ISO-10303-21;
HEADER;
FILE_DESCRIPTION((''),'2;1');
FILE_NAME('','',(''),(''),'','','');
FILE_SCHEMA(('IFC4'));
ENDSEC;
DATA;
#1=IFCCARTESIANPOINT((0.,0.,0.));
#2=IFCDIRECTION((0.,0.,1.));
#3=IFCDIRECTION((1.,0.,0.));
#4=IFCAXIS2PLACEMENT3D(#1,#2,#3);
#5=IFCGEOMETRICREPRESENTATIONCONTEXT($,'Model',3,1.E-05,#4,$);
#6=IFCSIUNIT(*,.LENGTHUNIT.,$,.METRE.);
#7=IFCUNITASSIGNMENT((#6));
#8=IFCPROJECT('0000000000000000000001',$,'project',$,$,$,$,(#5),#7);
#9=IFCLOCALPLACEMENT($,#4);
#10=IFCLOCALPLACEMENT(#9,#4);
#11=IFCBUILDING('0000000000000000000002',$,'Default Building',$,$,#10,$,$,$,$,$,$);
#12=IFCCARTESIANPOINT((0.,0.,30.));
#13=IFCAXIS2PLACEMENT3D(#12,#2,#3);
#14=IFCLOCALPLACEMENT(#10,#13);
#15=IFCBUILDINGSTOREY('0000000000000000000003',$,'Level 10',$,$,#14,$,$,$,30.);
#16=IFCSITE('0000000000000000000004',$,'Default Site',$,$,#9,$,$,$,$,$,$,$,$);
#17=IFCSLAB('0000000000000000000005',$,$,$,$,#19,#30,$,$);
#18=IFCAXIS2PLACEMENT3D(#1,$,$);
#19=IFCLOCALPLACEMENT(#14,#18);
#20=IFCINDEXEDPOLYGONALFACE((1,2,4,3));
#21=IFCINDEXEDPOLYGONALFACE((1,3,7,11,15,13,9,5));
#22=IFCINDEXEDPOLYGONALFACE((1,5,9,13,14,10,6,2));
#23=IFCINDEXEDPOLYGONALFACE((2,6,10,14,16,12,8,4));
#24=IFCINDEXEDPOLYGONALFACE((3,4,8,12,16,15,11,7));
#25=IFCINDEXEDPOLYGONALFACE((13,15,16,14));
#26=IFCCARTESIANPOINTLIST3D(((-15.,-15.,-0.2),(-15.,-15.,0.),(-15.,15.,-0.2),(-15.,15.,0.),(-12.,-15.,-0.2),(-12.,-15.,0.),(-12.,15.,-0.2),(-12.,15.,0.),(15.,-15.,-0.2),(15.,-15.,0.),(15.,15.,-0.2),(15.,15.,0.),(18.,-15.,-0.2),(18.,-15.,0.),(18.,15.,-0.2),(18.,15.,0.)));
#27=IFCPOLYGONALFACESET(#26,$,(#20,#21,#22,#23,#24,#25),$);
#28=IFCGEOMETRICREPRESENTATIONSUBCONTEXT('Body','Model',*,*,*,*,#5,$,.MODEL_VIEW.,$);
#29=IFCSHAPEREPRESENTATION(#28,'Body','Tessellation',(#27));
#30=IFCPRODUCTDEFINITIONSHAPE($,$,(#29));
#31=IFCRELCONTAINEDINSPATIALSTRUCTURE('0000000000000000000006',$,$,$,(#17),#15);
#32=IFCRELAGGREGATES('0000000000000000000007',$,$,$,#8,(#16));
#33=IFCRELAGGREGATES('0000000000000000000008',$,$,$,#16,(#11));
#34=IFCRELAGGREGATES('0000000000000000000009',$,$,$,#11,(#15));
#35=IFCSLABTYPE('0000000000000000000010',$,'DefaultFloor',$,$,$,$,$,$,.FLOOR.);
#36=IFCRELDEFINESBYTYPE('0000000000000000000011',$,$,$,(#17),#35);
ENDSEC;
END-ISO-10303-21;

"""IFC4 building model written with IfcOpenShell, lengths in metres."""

from ifc_helpers import new_model, si_unit, frame, origin_with_axes, place, context, subcontext, project, spatial, polyline, outline, extrude, type_object, element, save


model = new_model("IFC4")

# Units and contexts
model_context = context("Model", 3, precision=1e-05, world=origin_with_axes())
body_context = subcontext(model_context, "Body", "Model", "MODEL_VIEW")
ifc_project = project(units=[si_unit("LENGTHUNIT", "METRE")], contexts=[model_context])

# Site, building, storey
site_placement = place(None, origin_with_axes())
site = spatial("IfcSite", under=ifc_project, at=site_placement, Name="Default Site")
building_placement = place(site_placement, origin_with_axes())
building = spatial("IfcBuilding", under=site, at=building_placement, Name="Default Building")
storey_placement = place(building_placement, frame((0.0, 0.0, 30.0), z_axis=(0.0, 0.0, 1.0), x_axis=(1.0, 0.0, 0.0)))
storey = spatial("IfcBuildingStorey", under=building, at=storey_placement, Name="Level 10", Elevation=30.0)

# Slab
slab_type = type_object("IfcSlabType", Name="DefaultFloor", PredefinedType="FLOOR")
slab_placement = place(storey_placement, frame((0.0, 0.0, -30.0), z_axis=(0.0, 0.0, 1.0), x_axis=(1.0, 0.0, 0.0)))
element("IfcSlab", 1, at=slab_placement, inside=storey, type_object=slab_type, context=body_context, shape_type="SweptSolid", body=[
    extrude(outline(polyline([(-15.0, -15.0), (-15.0, 15.0), (-12.0, 15.0), (15.0, 15.0), (18.0, 15.0), (18.0, -15.0), (15.0, -15.0), (-12.0, -15.0), (-15.0, -15.0)])), frame((0.0, 0.0, 30.0), z_axis=(0.0, 0.0, 1.0), x_axis=(1.0, 0.0, 0.0)), (0.0, 0.0, -1.0), 0.2),
])

save(model, "model.ifc")
